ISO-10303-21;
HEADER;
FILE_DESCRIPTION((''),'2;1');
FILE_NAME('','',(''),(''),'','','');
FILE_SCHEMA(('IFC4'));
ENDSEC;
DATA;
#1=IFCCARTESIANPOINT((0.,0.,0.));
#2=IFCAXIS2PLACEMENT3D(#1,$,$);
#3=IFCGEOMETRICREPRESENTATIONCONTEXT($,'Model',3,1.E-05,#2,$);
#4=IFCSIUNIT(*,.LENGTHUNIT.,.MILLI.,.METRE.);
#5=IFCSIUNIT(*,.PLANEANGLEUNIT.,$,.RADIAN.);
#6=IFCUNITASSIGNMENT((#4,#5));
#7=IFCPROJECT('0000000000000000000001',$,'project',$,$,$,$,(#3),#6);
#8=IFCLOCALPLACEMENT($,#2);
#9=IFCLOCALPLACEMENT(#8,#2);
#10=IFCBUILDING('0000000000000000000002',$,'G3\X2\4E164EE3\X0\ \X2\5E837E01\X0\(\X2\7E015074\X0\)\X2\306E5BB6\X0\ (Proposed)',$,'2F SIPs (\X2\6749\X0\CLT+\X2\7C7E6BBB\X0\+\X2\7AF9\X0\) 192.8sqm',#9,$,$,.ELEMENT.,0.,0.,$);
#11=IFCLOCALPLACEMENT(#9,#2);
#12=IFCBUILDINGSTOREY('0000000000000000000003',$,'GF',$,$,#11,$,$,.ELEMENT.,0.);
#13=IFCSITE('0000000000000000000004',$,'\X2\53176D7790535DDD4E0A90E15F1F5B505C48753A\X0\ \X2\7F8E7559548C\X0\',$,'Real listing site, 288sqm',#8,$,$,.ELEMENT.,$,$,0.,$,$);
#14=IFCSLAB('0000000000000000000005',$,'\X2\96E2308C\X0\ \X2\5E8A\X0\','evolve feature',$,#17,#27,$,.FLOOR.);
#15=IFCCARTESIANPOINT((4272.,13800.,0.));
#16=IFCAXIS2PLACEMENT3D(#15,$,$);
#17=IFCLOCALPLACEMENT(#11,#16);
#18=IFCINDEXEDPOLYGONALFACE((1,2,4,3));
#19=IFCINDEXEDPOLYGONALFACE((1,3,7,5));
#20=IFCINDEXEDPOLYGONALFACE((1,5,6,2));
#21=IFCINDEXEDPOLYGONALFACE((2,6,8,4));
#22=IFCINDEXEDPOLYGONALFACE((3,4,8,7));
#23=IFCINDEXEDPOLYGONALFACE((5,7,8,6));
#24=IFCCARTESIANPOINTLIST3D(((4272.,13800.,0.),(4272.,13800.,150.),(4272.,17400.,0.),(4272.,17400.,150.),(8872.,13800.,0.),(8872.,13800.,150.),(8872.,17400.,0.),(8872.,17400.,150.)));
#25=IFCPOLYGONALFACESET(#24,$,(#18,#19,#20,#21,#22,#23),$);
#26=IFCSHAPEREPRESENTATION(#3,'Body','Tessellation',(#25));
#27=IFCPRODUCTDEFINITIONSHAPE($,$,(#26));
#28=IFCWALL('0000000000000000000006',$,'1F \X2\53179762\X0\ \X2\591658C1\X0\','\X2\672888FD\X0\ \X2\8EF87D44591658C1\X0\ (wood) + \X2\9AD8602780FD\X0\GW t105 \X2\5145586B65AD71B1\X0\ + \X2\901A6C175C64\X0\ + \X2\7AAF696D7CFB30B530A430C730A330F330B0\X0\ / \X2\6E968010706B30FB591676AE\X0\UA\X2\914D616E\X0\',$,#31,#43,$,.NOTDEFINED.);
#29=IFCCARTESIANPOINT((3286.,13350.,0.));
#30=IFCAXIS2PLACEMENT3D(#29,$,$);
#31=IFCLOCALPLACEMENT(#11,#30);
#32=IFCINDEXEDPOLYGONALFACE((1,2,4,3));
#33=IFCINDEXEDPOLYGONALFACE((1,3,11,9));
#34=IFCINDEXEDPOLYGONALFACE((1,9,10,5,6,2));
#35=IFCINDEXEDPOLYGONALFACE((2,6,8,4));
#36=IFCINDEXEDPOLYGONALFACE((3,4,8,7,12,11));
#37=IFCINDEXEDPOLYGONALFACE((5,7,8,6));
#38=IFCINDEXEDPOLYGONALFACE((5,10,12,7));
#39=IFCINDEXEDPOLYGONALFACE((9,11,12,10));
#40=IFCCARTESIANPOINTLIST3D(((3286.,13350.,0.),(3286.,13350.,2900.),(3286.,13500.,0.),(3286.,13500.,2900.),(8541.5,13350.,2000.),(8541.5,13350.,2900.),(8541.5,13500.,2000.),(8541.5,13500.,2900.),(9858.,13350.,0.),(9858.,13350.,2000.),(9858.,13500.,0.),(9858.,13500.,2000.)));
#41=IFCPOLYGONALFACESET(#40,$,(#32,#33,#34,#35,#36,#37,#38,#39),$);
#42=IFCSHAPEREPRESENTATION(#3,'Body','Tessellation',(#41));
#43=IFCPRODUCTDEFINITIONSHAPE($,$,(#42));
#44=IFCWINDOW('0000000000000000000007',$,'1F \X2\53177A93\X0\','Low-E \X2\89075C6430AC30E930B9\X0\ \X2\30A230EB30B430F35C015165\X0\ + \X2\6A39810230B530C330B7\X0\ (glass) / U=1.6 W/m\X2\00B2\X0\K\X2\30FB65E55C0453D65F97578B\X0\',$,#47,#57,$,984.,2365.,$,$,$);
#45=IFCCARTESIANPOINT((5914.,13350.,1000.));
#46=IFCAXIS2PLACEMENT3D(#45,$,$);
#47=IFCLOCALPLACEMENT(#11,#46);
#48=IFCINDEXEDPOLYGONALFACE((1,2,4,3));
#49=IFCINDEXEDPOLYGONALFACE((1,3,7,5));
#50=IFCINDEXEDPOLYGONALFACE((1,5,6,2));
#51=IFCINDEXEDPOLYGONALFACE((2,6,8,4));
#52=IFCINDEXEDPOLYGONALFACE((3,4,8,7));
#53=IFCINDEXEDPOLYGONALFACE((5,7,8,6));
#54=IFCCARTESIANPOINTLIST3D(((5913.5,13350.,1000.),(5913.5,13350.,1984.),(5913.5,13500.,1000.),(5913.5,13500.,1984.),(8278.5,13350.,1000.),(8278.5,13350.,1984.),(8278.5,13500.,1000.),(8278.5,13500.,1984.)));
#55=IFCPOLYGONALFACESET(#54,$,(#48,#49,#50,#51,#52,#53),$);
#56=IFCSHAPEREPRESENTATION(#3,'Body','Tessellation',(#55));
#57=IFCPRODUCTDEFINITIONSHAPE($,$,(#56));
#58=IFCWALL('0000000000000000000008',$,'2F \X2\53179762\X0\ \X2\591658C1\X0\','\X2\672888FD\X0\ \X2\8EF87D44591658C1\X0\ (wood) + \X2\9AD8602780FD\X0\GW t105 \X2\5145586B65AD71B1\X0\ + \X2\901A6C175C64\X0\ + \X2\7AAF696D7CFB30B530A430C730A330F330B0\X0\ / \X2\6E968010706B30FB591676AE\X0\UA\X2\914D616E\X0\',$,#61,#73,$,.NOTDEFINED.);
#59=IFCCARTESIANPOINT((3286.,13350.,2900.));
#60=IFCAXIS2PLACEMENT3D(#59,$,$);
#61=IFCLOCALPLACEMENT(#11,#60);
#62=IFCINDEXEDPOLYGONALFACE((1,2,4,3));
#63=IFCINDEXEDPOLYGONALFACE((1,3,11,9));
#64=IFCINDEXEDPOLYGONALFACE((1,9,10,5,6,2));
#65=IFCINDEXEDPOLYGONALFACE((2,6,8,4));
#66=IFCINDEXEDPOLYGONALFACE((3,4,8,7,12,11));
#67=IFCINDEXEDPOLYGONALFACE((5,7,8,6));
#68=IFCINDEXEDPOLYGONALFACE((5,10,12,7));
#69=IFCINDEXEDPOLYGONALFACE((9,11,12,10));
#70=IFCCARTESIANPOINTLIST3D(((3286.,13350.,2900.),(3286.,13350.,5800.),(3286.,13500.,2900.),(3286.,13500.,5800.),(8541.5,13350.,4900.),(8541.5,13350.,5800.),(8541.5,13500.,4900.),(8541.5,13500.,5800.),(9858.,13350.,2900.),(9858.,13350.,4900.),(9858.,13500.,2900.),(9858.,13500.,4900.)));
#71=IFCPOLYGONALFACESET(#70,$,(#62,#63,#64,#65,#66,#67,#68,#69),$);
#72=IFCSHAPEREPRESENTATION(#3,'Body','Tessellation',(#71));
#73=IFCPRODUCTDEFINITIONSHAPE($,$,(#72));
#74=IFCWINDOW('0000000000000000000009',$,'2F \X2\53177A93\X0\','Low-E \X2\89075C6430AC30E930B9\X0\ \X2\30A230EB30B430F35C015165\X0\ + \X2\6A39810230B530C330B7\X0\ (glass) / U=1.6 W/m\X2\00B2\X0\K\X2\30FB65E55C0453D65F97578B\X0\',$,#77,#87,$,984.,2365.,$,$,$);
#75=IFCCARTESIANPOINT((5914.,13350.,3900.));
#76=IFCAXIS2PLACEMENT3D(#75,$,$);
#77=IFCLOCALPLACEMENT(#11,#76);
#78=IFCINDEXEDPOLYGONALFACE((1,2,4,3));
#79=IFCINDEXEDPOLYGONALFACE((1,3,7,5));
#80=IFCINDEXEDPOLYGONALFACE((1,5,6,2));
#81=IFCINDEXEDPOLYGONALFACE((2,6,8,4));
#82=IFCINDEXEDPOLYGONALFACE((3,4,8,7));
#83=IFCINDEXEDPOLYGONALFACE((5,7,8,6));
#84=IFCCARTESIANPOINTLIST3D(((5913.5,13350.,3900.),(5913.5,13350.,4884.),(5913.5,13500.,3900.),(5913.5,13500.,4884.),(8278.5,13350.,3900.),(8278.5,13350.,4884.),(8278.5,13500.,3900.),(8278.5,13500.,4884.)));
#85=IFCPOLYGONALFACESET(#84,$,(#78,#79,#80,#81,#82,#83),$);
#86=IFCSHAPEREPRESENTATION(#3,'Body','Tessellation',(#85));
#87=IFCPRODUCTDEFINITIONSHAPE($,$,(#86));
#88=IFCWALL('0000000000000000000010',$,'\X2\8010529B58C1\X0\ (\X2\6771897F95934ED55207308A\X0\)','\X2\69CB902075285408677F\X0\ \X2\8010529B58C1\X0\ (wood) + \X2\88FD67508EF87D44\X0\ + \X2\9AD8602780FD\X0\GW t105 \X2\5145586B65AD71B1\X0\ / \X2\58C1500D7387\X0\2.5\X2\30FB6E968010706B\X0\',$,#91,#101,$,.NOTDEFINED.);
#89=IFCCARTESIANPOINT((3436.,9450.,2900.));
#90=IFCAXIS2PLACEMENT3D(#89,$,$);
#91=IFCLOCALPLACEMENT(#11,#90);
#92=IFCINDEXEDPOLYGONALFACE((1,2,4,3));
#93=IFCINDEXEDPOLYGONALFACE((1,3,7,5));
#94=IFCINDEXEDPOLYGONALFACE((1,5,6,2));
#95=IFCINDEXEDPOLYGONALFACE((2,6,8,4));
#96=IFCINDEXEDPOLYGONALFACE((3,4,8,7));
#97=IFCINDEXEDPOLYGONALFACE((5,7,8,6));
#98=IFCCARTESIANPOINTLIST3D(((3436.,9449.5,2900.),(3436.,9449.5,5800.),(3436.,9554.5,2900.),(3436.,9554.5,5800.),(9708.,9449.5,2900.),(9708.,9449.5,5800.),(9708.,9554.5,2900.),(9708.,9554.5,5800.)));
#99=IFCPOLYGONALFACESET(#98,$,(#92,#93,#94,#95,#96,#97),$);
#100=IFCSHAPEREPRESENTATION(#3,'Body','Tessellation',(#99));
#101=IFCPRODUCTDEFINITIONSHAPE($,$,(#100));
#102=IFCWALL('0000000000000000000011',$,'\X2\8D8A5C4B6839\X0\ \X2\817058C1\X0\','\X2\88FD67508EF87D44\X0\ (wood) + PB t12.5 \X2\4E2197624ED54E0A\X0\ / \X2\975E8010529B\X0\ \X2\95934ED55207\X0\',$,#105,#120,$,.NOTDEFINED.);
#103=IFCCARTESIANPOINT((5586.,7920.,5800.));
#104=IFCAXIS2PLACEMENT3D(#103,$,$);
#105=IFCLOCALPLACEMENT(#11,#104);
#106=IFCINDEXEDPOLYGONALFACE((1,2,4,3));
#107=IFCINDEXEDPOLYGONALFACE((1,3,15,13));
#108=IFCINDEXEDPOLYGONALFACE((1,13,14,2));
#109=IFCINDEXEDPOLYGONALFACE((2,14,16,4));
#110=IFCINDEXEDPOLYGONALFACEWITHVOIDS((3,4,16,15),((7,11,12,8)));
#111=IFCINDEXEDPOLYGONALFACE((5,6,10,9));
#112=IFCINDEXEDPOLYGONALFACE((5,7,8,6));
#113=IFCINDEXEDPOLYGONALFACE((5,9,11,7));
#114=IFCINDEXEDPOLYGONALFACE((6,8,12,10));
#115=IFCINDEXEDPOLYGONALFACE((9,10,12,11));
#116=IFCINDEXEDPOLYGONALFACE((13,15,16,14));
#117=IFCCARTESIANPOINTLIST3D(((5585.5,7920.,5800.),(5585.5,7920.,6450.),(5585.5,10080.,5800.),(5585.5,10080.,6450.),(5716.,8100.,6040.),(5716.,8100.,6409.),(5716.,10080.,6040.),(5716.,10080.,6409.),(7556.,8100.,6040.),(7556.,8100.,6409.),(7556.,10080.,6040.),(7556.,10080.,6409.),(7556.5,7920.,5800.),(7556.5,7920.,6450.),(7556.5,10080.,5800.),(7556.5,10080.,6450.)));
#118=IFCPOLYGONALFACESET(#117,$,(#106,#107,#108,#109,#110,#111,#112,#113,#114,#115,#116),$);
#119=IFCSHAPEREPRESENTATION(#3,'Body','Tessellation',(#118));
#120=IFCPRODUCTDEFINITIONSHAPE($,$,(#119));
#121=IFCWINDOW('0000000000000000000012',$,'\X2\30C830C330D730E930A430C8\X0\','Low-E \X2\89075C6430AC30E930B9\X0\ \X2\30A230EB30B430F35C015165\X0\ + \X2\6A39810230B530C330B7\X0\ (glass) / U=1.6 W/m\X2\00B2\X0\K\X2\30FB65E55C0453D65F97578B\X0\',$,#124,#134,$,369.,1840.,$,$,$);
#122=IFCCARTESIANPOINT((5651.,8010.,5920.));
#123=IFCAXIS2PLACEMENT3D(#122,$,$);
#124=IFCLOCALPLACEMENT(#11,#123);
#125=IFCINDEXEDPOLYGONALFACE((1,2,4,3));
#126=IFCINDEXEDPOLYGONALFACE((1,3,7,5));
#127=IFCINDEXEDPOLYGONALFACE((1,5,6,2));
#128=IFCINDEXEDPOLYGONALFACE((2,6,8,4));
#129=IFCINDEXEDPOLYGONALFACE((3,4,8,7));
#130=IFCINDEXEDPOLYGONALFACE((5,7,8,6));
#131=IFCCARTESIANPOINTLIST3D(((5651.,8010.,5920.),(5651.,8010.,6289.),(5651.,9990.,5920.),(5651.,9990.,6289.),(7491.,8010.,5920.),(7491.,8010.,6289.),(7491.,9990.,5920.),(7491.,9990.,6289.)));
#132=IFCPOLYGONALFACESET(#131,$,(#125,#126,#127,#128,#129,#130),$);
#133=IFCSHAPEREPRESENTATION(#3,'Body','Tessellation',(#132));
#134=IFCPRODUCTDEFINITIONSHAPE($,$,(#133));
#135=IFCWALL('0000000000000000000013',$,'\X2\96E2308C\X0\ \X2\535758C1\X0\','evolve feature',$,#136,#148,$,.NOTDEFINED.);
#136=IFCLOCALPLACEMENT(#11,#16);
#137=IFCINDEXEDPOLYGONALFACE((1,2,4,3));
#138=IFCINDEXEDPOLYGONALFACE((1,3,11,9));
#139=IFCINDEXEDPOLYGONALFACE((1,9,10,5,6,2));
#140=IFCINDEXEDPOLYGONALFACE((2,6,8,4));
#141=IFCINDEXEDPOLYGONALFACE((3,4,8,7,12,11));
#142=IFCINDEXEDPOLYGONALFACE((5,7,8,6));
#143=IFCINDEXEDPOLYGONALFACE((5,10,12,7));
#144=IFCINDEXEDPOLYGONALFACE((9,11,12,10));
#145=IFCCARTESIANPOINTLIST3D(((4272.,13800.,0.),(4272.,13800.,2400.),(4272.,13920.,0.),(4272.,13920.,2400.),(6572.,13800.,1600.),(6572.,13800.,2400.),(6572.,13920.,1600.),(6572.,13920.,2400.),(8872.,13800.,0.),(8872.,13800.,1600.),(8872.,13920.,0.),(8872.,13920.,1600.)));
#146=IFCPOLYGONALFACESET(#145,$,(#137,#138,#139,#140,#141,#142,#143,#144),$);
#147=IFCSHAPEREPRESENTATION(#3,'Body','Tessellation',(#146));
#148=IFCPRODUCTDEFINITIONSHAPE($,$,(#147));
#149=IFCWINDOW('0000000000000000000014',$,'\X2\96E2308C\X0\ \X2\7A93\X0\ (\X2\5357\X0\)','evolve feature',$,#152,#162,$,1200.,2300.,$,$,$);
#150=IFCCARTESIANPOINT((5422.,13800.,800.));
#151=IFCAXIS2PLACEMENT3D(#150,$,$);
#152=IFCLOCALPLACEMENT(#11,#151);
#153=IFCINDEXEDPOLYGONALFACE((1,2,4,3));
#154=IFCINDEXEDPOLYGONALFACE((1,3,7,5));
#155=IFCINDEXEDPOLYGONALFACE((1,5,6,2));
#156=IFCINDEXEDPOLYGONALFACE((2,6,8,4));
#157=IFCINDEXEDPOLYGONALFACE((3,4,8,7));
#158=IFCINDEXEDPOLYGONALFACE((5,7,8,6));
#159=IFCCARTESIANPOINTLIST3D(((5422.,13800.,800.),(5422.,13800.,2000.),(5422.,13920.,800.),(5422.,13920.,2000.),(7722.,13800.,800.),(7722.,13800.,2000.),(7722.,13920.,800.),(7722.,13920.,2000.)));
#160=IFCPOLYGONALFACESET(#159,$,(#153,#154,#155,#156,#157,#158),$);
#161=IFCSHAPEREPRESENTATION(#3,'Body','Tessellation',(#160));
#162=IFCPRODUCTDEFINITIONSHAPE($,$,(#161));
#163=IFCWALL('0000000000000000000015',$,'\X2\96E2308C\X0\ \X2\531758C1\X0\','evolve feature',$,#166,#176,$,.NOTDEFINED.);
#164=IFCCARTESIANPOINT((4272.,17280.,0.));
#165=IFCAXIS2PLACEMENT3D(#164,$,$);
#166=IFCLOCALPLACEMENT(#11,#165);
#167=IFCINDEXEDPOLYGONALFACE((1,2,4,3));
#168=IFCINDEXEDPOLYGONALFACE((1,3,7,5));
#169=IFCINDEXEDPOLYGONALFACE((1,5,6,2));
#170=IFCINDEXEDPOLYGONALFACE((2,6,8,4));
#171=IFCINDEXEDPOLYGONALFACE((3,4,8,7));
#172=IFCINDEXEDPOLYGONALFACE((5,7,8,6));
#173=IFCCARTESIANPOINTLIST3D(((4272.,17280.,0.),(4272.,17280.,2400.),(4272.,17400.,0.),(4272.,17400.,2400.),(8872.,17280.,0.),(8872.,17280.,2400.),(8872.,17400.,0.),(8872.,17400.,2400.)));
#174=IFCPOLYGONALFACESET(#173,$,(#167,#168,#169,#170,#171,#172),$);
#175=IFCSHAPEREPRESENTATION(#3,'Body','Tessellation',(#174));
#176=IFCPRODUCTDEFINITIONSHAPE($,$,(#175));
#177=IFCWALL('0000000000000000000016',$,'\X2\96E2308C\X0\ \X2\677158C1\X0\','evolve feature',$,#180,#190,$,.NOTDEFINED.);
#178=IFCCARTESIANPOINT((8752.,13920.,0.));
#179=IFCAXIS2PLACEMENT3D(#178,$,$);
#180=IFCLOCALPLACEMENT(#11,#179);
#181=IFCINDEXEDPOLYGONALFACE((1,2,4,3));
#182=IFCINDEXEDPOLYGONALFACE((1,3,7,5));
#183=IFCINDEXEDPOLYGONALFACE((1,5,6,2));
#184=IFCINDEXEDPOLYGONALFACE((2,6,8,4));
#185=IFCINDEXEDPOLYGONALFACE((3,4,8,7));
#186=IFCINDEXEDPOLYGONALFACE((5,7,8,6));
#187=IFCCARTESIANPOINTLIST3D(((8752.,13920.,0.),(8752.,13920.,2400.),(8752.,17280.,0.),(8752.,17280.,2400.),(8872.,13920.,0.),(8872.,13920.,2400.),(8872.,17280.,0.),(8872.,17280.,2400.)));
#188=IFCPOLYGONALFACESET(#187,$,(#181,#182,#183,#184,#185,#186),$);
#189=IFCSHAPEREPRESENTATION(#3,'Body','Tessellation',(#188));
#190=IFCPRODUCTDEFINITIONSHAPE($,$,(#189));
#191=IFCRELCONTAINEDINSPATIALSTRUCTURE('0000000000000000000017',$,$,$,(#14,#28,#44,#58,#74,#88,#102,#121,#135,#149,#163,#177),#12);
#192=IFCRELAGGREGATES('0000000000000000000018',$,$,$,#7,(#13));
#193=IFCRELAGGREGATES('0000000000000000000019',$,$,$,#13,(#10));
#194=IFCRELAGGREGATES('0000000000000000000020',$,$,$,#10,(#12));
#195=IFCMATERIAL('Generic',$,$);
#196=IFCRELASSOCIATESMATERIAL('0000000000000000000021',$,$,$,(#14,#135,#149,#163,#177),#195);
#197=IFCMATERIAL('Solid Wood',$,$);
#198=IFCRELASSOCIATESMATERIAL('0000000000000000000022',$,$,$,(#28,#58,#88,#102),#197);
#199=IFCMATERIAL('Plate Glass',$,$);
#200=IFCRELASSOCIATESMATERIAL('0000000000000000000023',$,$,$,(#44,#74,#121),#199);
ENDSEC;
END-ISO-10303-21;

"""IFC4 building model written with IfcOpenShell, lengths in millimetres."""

from ifc_helpers import new_model, si_unit, frame, frame_2d, origin, place, context, project, spatial, rectangle, extrude, material, element, fill, save


model = new_model("IFC4")

# Units and contexts
model_context = context("Model", 3, precision=1e-05, world=origin())
ifc_project = project(units=[si_unit("LENGTHUNIT", "METRE", prefix="MILLI"), si_unit("PLANEANGLEUNIT", "RADIAN")], contexts=[model_context])

# Site, building, storey
site_placement = place(None, origin())
site = spatial("IfcSite", under=ifc_project, at=site_placement, Name="北海道川上郡弟子屈町 美留和", ObjectType="Real listing site, 288sqm", CompositionType="ELEMENT", RefElevation=0.0)
building_placement = place(site_placement, origin())
building = spatial("IfcBuilding", under=site, at=building_placement, Name="G3世代 広縁(縁側)の家 (Proposed)", ObjectType="2F SIPs (杉CLT+籾殻+竹) 192.8sqm", CompositionType="ELEMENT", ElevationOfRefHeight=0.0, ElevationOfTerrain=0.0)
storey_placement = place(building_placement, origin())
storey = spatial("IfcBuildingStorey", under=building, at=storey_placement, Name="GF", CompositionType="ELEMENT", Elevation=0.0)

# Slab
ifc_material_1 = material(Name="Generic")
slab_placement = place(storey_placement, frame((4272.0, 13800.0, 0.0)))
element("IfcSlab", 1, at=slab_placement, inside=storey, material=ifc_material_1, Name="離れ 床", Description="evolve feature", PredefinedType="FLOOR", context=model_context, shape_type="SweptSolid", body=[
    extrude(rectangle(XDim=4600.0, YDim=3600.0, at=frame_2d((2300.0, 1800.0))), frame((4272.0, 13800.0, 0.0)), (0.0, 0.0, 1.0), 150.0),
])

# Wall, opening, window
ifc_material_2 = material(Name="Solid Wood")
wall_1_placement = place(storey_placement, frame((3286.0, 13350.0, 0.0)))
wall_1 = element("IfcWall", 2, at=wall_1_placement, inside=storey, material=ifc_material_2, Name="1F 北面 外壁", Description="木製 軸組外壁 (wood) + 高性能GW t105 充填断熱 + 通気層 + 窯業系サイディング / 準耐火・外皮UA配慮", PredefinedType="NOTDEFINED", context=model_context, shape_type="SweptSolid", body=[
    extrude(rectangle(XDim=6572.0, YDim=150.0, at=frame_2d((3286.0, 75.0))), frame((3286.0, 13350.0, 0.0)), (0.0, 0.0, 1.0), 2900.0),
])
opening_1_placement = place(storey_placement, frame((5914.0, 13350.0, 1000.0)))
opening_1 = element("IfcOpeningElement", 3, at=opening_1_placement, cuts=wall_1, PredefinedType="NOTDEFINED", context=model_context, shape_type="SweptSolid", body=[
    extrude(rectangle(XDim=2365.0, YDim=150.0, at=frame_2d((1182.0, 75.0))), frame((5914.0, 13350.0, 1000.0)), (0.0, 0.0, 1.0), 984.0),
])
ifc_material_3 = material(Name="Plate Glass")
window_1_placement = place(storey_placement, frame((5914.0, 13350.0, 1000.0)))
window_1 = element("IfcWindow", 4, at=window_1_placement, inside=storey, material=ifc_material_3, Name="1F 北窓", Description="Low-E 複層ガラス アルゴン封入 + 樹脂サッシ (glass) / U=1.6 W/m²K・日射取得型", OverallHeight=984.0, OverallWidth=2365.0, context=model_context, shape_type="SweptSolid", body=[
    extrude(rectangle(XDim=2365.0, YDim=150.0, at=frame_2d((1182.0, 75.0))), frame((5914.0, 13350.0, 1000.0)), (0.0, 0.0, 1.0), 984.0),
])
fill(opening_1, window_1)

# Wall, opening, window
wall_2_placement = place(storey_placement, frame((3286.0, 13350.0, 2900.0)))
wall_2 = element("IfcWall", 5, at=wall_2_placement, inside=storey, material=ifc_material_2, Name="2F 北面 外壁", Description="木製 軸組外壁 (wood) + 高性能GW t105 充填断熱 + 通気層 + 窯業系サイディング / 準耐火・外皮UA配慮", PredefinedType="NOTDEFINED", context=model_context, shape_type="SweptSolid", body=[
    extrude(rectangle(XDim=6572.0, YDim=150.0, at=frame_2d((3286.0, 75.0))), frame((3286.0, 13350.0, 2900.0)), (0.0, 0.0, 1.0), 2900.0),
])
opening_2_placement = place(storey_placement, frame((5914.0, 13350.0, 3900.0)))
opening_2 = element("IfcOpeningElement", 6, at=opening_2_placement, cuts=wall_2, PredefinedType="NOTDEFINED", context=model_context, shape_type="SweptSolid", body=[
    extrude(rectangle(XDim=2365.0, YDim=150.0, at=frame_2d((1182.0, 75.0))), frame((5914.0, 13350.0, 3900.0)), (0.0, 0.0, 1.0), 984.0),
])
window_2_placement = place(storey_placement, frame((5914.0, 13350.0, 3900.0)))
window_2 = element("IfcWindow", 7, at=window_2_placement, inside=storey, material=ifc_material_3, Name="2F 北窓", Description="Low-E 複層ガラス アルゴン封入 + 樹脂サッシ (glass) / U=1.6 W/m²K・日射取得型", OverallHeight=984.0, OverallWidth=2365.0, context=model_context, shape_type="SweptSolid", body=[
    extrude(rectangle(XDim=2365.0, YDim=150.0, at=frame_2d((1182.0, 75.0))), frame((5914.0, 13350.0, 3900.0)), (0.0, 0.0, 1.0), 984.0),
])
fill(opening_2, window_2)

# Wall
wall_3_placement = place(storey_placement, frame((3436.0, 9450.0, 2900.0)))
element("IfcWall", 8, at=wall_3_placement, inside=storey, material=ifc_material_2, Name="耐力壁 (東西間仕切り)", Description="構造用合板 耐力壁 (wood) + 製材軸組 + 高性能GW t105 充填断熱 / 壁倍率2.5・準耐火", PredefinedType="NOTDEFINED", context=model_context, shape_type="SweptSolid", body=[
    extrude(rectangle(XDim=6272.0, YDim=105.0, at=frame_2d((3136.0, 52.0))), frame((3436.0, 9450.0, 2900.0)), (0.0, 0.0, 1.0), 2900.0),
])

# Walls, openings, windows
wall_4_placement = place(storey_placement, frame((5586.0, 7920.0, 5800.0)))
wall_4 = element("IfcWall", 9, at=wall_4_placement, inside=storey, material=ifc_material_2, Name="越屋根 腰壁", Description="製材軸組 (wood) + PB t12.5 両面仕上 / 非耐力 間仕切", PredefinedType="NOTDEFINED", context=model_context, shape_type="SweptSolid", body=[
    extrude(rectangle(XDim=1971.0, YDim=2160.0, at=frame_2d((985.0, 1080.0))), frame((5586.0, 7920.0, 5800.0)), (0.0, 0.0, 1.0), 650.0),
])
opening_3_placement = place(storey_placement, frame((5651.0, 8010.0, 5920.0)))
opening_3 = element("IfcOpeningElement", 10, at=opening_3_placement, cuts=wall_4, PredefinedType="NOTDEFINED", context=model_context, shape_type="SweptSolid", body=[
    extrude(rectangle(XDim=1840.0, YDim=1980.0, at=frame_2d((920.0, 990.0))), frame((5651.0, 8010.0, 5920.0)), (0.0, 0.0, 1.0), 369.0),
])
window_3_placement = place(storey_placement, frame((5651.0, 8010.0, 5920.0)))
window_3 = element("IfcWindow", 11, at=window_3_placement, inside=storey, material=ifc_material_3, Name="トップライト", Description="Low-E 複層ガラス アルゴン封入 + 樹脂サッシ (glass) / U=1.6 W/m²K・日射取得型", OverallHeight=369.0, OverallWidth=1840.0, context=model_context, shape_type="SweptSolid", body=[
    extrude(rectangle(XDim=1840.0, YDim=1980.0, at=frame_2d((920.0, 990.0))), frame((5651.0, 8010.0, 5920.0)), (0.0, 0.0, 1.0), 369.0),
])
fill(opening_3, window_3)
wall_5_placement = place(storey_placement, frame((4272.0, 13800.0, 0.0)))
wall_5 = element("IfcWall", 12, at=wall_5_placement, inside=storey, material=ifc_material_1, Name="離れ 南壁", Description="evolve feature", PredefinedType="NOTDEFINED", context=model_context, shape_type="SweptSolid", body=[
    extrude(rectangle(XDim=4600.0, YDim=120.0, at=frame_2d((2300.0, 60.0))), frame((4272.0, 13800.0, 0.0)), (0.0, 0.0, 1.0), 2400.0),
])
opening_4_placement = place(storey_placement, frame((5422.0, 13800.0, 800.0)))
opening_4 = element("IfcOpeningElement", 13, at=opening_4_placement, cuts=wall_5, PredefinedType="NOTDEFINED", context=model_context, shape_type="SweptSolid", body=[
    extrude(rectangle(XDim=2300.0, YDim=120.0, at=frame_2d((1150.0, 60.0))), frame((5422.0, 13800.0, 800.0)), (0.0, 0.0, 1.0), 1200.0),
])
window_4_placement = place(storey_placement, frame((5422.0, 13800.0, 800.0)))
window_4 = element("IfcWindow", 14, at=window_4_placement, inside=storey, material=ifc_material_1, Name="離れ 窓 (南)", Description="evolve feature", OverallHeight=1200.0, OverallWidth=2300.0, context=model_context, shape_type="SweptSolid", body=[
    extrude(rectangle(XDim=2300.0, YDim=120.0, at=frame_2d((1150.0, 60.0))), frame((5422.0, 13800.0, 800.0)), (0.0, 0.0, 1.0), 1200.0),
])
fill(opening_4, window_4)

# Walls
wall_6_placement = place(storey_placement, frame((4272.0, 17280.0, 0.0)))
element("IfcWall", 15, at=wall_6_placement, inside=storey, material=ifc_material_1, Name="離れ 北壁", Description="evolve feature", PredefinedType="NOTDEFINED", context=model_context, shape_type="SweptSolid", body=[
    extrude(rectangle(XDim=4600.0, YDim=120.0, at=frame_2d((2300.0, 60.0))), frame((4272.0, 17280.0, 0.0)), (0.0, 0.0, 1.0), 2400.0),
])
wall_7_placement = place(storey_placement, frame((8752.0, 13920.0, 0.0)))
element("IfcWall", 16, at=wall_7_placement, inside=storey, material=ifc_material_1, Name="離れ 東壁", Description="evolve feature", PredefinedType="NOTDEFINED", context=model_context, shape_type="SweptSolid", body=[
    extrude(rectangle(XDim=120.0, YDim=3360.0, at=frame_2d((60.0, 1680.0))), frame((8752.0, 13920.0, 0.0)), (0.0, 0.0, 1.0), 2400.0),
])

save(model, "model.ifc")
